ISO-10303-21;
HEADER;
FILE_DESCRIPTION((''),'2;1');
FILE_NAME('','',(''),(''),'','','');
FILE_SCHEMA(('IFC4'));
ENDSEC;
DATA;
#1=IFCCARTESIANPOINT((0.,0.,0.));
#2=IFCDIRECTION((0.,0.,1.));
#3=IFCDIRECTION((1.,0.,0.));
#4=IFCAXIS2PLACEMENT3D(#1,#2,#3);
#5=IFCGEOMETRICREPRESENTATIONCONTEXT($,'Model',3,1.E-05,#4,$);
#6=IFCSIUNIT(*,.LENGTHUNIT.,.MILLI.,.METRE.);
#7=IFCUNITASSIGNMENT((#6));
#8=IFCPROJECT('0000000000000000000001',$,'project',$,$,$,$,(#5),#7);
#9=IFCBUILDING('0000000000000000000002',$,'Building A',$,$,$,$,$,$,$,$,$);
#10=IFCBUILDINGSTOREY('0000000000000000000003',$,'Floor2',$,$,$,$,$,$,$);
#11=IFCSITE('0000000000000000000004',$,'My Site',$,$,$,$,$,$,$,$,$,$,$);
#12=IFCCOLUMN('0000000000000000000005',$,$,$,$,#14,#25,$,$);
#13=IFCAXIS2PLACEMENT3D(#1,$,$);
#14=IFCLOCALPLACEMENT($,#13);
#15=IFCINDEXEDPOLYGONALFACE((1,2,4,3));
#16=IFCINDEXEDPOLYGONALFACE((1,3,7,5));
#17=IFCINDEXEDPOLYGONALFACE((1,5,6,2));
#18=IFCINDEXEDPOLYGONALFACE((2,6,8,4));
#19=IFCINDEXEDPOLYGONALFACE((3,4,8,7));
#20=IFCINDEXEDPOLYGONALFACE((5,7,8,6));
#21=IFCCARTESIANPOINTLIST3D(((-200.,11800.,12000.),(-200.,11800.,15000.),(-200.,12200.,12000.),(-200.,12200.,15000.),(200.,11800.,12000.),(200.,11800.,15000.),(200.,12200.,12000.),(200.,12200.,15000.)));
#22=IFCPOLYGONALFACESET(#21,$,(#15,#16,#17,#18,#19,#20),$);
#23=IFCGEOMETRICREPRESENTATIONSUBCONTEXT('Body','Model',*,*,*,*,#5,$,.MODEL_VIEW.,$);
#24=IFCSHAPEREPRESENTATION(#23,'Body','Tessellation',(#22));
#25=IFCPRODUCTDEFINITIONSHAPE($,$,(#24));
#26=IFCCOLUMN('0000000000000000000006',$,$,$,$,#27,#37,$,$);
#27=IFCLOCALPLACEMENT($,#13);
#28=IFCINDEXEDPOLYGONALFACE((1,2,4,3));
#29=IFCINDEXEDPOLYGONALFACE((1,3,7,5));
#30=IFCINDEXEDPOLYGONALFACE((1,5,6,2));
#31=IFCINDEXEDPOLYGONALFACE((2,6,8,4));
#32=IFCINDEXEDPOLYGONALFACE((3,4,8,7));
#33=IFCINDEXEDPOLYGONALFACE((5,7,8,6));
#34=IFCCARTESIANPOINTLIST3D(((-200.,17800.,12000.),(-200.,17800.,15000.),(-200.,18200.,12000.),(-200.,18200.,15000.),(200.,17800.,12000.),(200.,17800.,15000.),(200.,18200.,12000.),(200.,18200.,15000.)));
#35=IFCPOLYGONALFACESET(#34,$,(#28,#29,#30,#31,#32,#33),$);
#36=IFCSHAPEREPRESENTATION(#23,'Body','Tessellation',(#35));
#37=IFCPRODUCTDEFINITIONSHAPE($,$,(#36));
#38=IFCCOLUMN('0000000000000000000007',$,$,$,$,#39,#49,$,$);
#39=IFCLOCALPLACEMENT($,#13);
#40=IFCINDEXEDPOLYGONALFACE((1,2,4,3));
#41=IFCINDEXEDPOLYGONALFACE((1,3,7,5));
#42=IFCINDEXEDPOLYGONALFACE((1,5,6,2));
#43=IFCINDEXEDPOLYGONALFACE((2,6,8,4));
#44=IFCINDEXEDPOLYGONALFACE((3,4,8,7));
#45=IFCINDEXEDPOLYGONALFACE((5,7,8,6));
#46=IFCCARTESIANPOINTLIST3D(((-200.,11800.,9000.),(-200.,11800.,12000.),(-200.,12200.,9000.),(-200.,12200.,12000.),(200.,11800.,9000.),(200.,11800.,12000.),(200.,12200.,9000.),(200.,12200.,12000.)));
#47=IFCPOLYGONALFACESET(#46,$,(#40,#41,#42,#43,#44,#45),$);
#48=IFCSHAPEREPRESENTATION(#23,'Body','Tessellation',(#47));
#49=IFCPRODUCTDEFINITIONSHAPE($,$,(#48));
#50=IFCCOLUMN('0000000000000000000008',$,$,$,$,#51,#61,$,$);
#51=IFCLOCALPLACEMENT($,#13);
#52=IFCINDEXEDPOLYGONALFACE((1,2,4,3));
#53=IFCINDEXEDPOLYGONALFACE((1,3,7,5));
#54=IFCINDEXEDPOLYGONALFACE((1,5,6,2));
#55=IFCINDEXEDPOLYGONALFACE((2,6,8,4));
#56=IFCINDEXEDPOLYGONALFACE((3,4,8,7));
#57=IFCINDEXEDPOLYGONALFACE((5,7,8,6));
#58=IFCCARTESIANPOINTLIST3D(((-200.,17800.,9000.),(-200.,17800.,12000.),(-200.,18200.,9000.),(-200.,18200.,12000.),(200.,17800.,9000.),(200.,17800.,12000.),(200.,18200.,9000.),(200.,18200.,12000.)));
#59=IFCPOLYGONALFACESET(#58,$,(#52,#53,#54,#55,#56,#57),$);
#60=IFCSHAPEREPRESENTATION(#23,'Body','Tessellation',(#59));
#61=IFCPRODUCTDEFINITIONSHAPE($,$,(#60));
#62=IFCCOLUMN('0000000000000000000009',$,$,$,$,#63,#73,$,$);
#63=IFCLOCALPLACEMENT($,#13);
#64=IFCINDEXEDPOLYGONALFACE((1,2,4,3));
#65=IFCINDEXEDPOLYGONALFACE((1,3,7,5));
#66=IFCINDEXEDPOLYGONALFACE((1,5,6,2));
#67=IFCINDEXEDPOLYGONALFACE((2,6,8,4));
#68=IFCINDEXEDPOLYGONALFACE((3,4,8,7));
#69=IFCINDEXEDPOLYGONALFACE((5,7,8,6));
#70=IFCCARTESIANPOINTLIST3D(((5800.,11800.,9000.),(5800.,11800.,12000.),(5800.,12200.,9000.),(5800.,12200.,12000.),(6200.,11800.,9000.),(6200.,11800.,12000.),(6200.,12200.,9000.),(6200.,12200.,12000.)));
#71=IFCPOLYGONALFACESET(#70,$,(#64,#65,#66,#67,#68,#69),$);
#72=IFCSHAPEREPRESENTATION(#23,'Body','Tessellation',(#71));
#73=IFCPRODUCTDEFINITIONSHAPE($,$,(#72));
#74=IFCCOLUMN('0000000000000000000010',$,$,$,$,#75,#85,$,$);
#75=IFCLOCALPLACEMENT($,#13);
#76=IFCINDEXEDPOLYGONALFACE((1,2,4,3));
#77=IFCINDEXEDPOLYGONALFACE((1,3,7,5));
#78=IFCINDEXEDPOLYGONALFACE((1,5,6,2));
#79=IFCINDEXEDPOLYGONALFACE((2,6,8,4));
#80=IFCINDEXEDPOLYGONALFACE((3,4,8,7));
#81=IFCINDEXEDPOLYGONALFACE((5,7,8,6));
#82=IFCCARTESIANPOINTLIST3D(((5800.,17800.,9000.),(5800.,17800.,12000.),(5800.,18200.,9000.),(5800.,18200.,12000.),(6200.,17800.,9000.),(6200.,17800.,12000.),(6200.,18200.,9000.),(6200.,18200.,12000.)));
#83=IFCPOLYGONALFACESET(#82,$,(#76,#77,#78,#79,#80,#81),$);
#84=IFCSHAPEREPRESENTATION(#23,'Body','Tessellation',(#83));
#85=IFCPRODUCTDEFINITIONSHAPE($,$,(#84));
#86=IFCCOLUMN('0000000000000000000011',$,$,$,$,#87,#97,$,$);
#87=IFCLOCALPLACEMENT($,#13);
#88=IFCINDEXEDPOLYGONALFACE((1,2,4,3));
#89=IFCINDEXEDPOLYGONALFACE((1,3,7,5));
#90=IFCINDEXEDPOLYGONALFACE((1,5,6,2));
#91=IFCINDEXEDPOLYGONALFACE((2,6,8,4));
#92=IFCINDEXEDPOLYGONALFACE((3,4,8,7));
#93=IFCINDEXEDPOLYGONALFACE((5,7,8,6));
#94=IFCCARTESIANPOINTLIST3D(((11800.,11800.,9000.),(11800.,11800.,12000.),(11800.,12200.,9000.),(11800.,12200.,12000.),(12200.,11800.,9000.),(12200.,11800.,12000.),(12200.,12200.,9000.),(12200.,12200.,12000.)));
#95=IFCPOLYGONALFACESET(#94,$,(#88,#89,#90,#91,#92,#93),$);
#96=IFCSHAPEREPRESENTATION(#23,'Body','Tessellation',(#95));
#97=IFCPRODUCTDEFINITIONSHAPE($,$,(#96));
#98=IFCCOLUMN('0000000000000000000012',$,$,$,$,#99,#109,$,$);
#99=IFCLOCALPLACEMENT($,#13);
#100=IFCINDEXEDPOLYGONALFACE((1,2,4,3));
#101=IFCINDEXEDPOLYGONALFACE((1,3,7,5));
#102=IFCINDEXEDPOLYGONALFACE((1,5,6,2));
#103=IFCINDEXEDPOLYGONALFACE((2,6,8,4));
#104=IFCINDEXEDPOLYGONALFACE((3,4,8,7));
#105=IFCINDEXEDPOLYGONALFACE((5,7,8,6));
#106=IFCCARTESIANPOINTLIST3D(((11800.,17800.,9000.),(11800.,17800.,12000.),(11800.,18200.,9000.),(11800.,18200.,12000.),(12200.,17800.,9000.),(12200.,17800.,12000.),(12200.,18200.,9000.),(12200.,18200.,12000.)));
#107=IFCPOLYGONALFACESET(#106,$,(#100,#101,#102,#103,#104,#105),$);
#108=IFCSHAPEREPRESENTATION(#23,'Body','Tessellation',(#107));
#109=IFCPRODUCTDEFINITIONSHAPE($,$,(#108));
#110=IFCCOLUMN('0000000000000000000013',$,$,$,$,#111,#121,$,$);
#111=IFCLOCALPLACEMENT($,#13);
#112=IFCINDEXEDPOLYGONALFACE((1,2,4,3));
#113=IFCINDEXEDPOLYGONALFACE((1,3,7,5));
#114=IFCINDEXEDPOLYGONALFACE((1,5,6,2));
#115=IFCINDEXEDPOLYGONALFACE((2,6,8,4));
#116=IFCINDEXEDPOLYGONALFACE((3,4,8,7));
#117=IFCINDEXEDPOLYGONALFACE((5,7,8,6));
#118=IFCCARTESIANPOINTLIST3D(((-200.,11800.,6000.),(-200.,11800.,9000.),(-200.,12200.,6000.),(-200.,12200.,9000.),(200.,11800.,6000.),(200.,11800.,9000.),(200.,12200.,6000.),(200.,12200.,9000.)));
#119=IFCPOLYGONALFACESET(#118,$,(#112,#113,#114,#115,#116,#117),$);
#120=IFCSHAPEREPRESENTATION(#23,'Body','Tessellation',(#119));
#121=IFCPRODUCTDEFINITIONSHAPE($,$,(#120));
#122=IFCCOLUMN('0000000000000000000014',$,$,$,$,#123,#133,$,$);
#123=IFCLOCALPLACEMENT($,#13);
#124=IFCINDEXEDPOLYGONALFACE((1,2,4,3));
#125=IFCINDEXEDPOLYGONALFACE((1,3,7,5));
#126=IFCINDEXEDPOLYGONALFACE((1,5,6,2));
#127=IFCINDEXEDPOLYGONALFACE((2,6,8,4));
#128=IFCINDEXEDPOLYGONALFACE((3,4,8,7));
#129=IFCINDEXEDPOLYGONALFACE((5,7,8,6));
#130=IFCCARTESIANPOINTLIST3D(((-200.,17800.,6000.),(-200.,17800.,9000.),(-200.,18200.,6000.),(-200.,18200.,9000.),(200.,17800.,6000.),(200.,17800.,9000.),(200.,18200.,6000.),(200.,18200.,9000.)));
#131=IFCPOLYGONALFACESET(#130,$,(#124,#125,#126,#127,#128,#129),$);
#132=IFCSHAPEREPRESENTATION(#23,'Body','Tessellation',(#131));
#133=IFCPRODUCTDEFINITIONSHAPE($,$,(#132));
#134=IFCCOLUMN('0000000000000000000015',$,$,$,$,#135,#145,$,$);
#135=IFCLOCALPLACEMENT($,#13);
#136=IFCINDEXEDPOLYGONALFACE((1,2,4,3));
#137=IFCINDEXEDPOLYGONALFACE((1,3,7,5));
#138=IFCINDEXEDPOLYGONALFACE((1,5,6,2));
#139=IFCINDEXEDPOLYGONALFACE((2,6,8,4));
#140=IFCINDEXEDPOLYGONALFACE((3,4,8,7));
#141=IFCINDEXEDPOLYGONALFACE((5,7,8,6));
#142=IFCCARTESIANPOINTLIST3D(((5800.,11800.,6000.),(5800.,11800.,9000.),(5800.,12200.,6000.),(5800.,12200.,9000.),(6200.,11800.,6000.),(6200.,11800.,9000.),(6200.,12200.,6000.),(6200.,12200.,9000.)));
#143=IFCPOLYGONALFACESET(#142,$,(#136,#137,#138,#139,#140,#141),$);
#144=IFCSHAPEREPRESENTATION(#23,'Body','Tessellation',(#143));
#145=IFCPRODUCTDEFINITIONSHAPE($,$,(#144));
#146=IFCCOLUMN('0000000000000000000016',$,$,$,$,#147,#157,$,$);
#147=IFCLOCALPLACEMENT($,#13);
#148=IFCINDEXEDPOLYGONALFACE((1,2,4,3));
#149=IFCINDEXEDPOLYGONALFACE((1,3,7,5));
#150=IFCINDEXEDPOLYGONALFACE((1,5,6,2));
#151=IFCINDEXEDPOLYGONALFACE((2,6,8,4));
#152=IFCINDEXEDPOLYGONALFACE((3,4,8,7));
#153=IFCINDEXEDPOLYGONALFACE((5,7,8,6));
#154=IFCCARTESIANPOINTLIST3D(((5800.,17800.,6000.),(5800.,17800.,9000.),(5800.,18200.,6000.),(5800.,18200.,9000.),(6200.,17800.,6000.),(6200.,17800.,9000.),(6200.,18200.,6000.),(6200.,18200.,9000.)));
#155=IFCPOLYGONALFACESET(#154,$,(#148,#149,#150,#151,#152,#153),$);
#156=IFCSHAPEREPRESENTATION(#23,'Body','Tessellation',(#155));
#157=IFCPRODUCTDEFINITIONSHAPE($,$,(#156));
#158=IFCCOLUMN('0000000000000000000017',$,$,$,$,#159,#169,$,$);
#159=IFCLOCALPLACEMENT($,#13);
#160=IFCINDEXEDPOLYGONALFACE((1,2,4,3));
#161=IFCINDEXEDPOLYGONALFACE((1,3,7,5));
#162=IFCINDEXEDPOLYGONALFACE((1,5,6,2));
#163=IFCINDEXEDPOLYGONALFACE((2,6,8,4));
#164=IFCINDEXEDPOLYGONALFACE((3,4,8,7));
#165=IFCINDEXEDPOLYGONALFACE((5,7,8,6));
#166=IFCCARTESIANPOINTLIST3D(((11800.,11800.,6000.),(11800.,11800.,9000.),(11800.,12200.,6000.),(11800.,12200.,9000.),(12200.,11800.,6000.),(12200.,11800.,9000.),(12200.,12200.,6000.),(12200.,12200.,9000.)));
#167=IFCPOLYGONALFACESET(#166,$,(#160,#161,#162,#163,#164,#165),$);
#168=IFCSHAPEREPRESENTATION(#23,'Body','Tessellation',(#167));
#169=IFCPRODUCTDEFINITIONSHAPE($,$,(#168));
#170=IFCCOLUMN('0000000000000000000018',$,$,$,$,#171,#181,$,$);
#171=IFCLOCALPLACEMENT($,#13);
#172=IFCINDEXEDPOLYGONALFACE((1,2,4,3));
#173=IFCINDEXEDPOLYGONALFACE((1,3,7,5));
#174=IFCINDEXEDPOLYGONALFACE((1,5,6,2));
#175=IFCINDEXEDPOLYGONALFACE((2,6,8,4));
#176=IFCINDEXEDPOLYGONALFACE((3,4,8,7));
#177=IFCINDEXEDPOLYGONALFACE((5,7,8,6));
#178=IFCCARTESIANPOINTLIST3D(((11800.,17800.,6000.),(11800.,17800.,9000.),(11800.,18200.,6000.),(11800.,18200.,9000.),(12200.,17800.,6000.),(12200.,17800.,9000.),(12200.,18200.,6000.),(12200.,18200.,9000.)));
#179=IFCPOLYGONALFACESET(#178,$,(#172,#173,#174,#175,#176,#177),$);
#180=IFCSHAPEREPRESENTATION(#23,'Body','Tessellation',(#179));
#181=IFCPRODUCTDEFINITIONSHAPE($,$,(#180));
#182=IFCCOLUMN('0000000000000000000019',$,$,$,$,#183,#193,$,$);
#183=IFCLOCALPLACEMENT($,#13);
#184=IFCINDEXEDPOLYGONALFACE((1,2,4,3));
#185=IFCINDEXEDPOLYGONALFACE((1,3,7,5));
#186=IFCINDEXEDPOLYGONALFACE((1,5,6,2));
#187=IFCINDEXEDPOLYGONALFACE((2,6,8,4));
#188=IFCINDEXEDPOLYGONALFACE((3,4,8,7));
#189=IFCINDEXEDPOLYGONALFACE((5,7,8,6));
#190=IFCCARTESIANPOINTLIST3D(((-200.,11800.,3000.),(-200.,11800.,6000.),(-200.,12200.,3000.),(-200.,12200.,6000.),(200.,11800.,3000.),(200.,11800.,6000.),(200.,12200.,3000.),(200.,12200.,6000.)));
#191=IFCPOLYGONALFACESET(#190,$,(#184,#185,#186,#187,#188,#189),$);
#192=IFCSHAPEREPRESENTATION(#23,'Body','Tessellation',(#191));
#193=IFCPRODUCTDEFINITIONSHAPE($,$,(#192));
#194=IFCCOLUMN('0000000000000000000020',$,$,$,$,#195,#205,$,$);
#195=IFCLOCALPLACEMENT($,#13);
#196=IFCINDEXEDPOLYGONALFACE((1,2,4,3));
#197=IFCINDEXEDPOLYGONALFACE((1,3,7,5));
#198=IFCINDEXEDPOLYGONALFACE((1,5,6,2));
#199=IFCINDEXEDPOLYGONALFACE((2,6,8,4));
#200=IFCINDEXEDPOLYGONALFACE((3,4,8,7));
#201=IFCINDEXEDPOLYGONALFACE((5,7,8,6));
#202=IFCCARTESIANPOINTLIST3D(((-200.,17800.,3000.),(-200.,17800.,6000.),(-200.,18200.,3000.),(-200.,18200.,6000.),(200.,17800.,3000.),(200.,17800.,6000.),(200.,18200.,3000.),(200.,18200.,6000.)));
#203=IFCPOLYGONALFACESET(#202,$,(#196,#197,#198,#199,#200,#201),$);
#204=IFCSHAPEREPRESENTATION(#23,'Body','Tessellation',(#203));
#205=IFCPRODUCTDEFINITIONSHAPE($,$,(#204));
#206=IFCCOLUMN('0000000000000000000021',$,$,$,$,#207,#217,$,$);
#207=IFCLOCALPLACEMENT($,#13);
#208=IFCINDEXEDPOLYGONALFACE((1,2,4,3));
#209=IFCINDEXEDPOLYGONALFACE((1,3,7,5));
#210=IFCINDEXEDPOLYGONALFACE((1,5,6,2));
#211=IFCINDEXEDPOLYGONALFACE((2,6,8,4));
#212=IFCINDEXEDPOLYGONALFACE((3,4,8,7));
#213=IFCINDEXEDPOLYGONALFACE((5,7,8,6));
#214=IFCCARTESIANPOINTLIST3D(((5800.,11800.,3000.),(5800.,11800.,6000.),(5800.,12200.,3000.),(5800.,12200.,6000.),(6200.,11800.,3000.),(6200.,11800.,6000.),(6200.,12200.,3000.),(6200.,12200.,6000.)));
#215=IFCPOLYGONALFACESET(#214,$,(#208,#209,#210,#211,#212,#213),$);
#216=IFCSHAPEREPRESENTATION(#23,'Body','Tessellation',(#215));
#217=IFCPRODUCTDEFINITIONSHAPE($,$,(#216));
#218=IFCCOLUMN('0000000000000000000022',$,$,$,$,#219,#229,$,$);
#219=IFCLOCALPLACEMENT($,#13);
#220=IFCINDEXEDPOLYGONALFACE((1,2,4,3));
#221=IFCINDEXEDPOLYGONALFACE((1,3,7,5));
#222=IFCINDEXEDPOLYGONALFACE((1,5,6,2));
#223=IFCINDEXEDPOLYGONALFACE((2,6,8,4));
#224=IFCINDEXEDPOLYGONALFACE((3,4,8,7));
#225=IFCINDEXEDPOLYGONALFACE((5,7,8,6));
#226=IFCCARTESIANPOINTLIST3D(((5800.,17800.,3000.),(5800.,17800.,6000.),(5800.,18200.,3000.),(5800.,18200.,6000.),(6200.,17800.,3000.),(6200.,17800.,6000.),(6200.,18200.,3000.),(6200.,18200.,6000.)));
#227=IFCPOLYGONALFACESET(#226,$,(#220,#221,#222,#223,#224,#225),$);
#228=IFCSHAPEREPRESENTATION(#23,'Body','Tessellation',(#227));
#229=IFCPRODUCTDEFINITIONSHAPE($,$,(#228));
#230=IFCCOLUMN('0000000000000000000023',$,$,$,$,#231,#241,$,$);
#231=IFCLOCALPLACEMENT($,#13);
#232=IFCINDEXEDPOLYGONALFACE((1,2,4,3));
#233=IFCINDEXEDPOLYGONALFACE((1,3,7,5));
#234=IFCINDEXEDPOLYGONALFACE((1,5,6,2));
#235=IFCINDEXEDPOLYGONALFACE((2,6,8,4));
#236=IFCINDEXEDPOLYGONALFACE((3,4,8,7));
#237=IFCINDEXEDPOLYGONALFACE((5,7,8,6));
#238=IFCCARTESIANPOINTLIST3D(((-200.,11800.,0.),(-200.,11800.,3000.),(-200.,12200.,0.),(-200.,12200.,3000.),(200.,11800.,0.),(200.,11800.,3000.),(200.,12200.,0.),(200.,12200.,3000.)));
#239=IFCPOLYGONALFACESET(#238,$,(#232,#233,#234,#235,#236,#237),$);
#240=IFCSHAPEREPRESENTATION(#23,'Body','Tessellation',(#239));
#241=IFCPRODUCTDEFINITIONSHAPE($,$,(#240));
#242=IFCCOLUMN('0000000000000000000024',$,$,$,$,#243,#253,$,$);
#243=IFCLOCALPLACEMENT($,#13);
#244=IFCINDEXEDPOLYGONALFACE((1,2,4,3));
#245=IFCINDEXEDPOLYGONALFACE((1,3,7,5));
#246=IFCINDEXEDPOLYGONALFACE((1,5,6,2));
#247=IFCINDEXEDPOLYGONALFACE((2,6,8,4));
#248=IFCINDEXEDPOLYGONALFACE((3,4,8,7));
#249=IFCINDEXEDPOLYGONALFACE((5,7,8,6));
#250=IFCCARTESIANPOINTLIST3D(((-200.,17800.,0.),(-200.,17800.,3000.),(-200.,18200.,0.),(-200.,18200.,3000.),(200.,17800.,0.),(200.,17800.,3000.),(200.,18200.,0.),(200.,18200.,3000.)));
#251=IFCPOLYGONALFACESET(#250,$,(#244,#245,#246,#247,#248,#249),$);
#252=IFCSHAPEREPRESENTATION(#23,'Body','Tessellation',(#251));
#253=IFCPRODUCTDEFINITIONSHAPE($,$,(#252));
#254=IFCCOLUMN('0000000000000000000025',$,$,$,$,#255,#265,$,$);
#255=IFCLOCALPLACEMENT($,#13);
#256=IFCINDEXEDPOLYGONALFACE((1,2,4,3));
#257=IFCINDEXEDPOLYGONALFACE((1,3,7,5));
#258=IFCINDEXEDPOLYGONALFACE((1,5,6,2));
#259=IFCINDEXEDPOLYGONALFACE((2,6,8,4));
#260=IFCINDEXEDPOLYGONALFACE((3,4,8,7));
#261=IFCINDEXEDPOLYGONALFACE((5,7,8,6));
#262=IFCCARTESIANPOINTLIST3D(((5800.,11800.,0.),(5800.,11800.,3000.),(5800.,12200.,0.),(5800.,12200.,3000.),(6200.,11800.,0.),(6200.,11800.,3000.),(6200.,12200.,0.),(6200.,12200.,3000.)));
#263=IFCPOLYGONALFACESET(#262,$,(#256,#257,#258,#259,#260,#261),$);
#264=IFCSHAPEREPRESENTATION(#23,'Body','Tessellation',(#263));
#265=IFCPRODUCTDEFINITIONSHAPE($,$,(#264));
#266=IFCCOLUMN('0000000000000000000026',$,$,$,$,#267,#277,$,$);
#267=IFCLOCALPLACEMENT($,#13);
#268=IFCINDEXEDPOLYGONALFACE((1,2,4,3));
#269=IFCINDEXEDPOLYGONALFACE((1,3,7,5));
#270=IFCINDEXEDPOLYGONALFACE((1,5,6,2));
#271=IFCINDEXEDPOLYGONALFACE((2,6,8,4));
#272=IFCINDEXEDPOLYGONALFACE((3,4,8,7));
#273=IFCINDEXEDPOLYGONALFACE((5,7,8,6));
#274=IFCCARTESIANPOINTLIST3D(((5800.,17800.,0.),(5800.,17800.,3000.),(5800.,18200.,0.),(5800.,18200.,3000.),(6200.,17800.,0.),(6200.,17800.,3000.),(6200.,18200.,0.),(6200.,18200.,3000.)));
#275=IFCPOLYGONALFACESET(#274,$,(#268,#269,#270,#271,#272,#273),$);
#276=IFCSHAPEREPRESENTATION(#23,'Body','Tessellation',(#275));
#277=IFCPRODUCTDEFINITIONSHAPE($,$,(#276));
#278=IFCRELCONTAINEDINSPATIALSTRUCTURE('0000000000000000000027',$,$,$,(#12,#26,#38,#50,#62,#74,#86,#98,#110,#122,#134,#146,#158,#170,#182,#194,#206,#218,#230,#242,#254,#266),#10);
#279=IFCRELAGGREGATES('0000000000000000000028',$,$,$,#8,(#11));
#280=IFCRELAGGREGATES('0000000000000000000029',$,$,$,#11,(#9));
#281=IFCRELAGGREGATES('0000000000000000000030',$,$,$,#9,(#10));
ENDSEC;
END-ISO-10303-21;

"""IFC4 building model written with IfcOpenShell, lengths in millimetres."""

from ifc_helpers import new_model, si_unit, frame, origin_with_axes, place, context, subcontext, project, spatial, line, indexed_curve, outline, extrude, element, save


model = new_model("IFC4")

# Units and contexts
model_context = context("Model", 3, precision=1e-05, world=origin_with_axes())
body_context = subcontext(model_context, "Body", "Model", "MODEL_VIEW")
ifc_project = project(units=[si_unit("LENGTHUNIT", "METRE", prefix="MILLI")], contexts=[model_context])

# Site, building, storey
site = spatial("IfcSite", under=ifc_project, Name="My Site")
building = spatial("IfcBuilding", under=site, Name="Building A")
storey = spatial("IfcBuildingStorey", under=building, Name="Floor2")

# Columns
for number, where, z_axis, x_axis in (
    (1, (0.0, 12000.0, 12000.0), (0.0, 0.0, 1.0), (1.0, 0.0, 0.0)),
    (2, (0.0, 18000.0, 12000.0), (0.0, 0.0, 1.0), (1.0, 0.0, 0.0)),
    (3, (0.0, 12000.0, 9000.0), (0.0, 0.0, 1.0), (1.0, 0.0, 0.0)),
    (4, (0.0, 18000.0, 9000.0), (0.0, 0.0, 1.0), (1.0, 0.0, 0.0)),
    (5, (6000.0, 12000.0, 9000.0), (0.0, 0.0, 1.0), (1.0, 0.0, 0.0)),
    (6, (6000.0, 18000.0, 9000.0), (0.0, 0.0, 1.0), (1.0, 0.0, 0.0)),
    (7, (12000.0, 12000.0, 9000.0), (0.0, 0.0, 1.0), (1.0, 0.0, 0.0)),
    (8, (12000.0, 18000.0, 9000.0), (0.0, 0.0, 1.0), (1.0, 0.0, 0.0)),
    (9, (0.0, 12000.0, 6000.0), (0.0, 0.0, 1.0), (1.0, 0.0, 0.0)),
    (10, (0.0, 18000.0, 6000.0), (0.0, 0.0, 1.0), (1.0, 0.0, 0.0)),
    (11, (6000.0, 12000.0, 6000.0), (0.0, 0.0, 1.0), (1.0, 0.0, 0.0)),
    (12, (6000.0, 18000.0, 6000.0), (0.0, 0.0, 1.0), (1.0, 0.0, 0.0)),
    (13, (12000.0, 12000.0, 6000.0), (0.0, 0.0, 1.0), (1.0, 0.0, 0.0)),
    (14, (12000.0, 18000.0, 6000.0), (0.0, 0.0, 1.0), (1.0, 0.0, 0.0)),
    (15, (0.0, 12000.0, 3000.0), (0.0, 0.0, 1.0), (1.0, 0.0, 0.0)),
    (16, (0.0, 18000.0, 3000.0), (0.0, 0.0, 1.0), (1.0, 0.0, 0.0)),
    (17, (6000.0, 12000.0, 3000.0), (0.0, 0.0, 1.0), (1.0, 0.0, 0.0)),
    (18, (6000.0, 18000.0, 3000.0), (0.0, 0.0, 1.0), (1.0, 0.0, 0.0)),
    (19, (0.0, 12000.0, 0.0), (0.0, 0.0, 1.0), (1.0, 0.0, 0.0)),
    (20, (0.0, 18000.0, 0.0), (0.0, 0.0, 1.0), (1.0, 0.0, 0.0)),
    (21, (6000.0, 12000.0, 0.0), (0.0, 0.0, 1.0), (1.0, 0.0, 0.0)),
    (22, (6000.0, 18000.0, 0.0), (0.0, 0.0, 1.0), (1.0, 0.0, 0.0)),
):
    element("IfcColumn", number, at=place(None, frame(where, z_axis=z_axis, x_axis=x_axis)), inside=storey, context=body_context, shape_type="SweptSolid", body=[
        extrude(outline(indexed_curve([(-200.0, -200.0), (200.0, -200.0), (200.0, 200.0), (-200.0, 200.0)], segments=[line(1, 2, 3, 4, 1)])), origin_with_axes(), (0.0, 0.0, 1.0), 3000.0),
    ])

save(model, "model.ifc")
